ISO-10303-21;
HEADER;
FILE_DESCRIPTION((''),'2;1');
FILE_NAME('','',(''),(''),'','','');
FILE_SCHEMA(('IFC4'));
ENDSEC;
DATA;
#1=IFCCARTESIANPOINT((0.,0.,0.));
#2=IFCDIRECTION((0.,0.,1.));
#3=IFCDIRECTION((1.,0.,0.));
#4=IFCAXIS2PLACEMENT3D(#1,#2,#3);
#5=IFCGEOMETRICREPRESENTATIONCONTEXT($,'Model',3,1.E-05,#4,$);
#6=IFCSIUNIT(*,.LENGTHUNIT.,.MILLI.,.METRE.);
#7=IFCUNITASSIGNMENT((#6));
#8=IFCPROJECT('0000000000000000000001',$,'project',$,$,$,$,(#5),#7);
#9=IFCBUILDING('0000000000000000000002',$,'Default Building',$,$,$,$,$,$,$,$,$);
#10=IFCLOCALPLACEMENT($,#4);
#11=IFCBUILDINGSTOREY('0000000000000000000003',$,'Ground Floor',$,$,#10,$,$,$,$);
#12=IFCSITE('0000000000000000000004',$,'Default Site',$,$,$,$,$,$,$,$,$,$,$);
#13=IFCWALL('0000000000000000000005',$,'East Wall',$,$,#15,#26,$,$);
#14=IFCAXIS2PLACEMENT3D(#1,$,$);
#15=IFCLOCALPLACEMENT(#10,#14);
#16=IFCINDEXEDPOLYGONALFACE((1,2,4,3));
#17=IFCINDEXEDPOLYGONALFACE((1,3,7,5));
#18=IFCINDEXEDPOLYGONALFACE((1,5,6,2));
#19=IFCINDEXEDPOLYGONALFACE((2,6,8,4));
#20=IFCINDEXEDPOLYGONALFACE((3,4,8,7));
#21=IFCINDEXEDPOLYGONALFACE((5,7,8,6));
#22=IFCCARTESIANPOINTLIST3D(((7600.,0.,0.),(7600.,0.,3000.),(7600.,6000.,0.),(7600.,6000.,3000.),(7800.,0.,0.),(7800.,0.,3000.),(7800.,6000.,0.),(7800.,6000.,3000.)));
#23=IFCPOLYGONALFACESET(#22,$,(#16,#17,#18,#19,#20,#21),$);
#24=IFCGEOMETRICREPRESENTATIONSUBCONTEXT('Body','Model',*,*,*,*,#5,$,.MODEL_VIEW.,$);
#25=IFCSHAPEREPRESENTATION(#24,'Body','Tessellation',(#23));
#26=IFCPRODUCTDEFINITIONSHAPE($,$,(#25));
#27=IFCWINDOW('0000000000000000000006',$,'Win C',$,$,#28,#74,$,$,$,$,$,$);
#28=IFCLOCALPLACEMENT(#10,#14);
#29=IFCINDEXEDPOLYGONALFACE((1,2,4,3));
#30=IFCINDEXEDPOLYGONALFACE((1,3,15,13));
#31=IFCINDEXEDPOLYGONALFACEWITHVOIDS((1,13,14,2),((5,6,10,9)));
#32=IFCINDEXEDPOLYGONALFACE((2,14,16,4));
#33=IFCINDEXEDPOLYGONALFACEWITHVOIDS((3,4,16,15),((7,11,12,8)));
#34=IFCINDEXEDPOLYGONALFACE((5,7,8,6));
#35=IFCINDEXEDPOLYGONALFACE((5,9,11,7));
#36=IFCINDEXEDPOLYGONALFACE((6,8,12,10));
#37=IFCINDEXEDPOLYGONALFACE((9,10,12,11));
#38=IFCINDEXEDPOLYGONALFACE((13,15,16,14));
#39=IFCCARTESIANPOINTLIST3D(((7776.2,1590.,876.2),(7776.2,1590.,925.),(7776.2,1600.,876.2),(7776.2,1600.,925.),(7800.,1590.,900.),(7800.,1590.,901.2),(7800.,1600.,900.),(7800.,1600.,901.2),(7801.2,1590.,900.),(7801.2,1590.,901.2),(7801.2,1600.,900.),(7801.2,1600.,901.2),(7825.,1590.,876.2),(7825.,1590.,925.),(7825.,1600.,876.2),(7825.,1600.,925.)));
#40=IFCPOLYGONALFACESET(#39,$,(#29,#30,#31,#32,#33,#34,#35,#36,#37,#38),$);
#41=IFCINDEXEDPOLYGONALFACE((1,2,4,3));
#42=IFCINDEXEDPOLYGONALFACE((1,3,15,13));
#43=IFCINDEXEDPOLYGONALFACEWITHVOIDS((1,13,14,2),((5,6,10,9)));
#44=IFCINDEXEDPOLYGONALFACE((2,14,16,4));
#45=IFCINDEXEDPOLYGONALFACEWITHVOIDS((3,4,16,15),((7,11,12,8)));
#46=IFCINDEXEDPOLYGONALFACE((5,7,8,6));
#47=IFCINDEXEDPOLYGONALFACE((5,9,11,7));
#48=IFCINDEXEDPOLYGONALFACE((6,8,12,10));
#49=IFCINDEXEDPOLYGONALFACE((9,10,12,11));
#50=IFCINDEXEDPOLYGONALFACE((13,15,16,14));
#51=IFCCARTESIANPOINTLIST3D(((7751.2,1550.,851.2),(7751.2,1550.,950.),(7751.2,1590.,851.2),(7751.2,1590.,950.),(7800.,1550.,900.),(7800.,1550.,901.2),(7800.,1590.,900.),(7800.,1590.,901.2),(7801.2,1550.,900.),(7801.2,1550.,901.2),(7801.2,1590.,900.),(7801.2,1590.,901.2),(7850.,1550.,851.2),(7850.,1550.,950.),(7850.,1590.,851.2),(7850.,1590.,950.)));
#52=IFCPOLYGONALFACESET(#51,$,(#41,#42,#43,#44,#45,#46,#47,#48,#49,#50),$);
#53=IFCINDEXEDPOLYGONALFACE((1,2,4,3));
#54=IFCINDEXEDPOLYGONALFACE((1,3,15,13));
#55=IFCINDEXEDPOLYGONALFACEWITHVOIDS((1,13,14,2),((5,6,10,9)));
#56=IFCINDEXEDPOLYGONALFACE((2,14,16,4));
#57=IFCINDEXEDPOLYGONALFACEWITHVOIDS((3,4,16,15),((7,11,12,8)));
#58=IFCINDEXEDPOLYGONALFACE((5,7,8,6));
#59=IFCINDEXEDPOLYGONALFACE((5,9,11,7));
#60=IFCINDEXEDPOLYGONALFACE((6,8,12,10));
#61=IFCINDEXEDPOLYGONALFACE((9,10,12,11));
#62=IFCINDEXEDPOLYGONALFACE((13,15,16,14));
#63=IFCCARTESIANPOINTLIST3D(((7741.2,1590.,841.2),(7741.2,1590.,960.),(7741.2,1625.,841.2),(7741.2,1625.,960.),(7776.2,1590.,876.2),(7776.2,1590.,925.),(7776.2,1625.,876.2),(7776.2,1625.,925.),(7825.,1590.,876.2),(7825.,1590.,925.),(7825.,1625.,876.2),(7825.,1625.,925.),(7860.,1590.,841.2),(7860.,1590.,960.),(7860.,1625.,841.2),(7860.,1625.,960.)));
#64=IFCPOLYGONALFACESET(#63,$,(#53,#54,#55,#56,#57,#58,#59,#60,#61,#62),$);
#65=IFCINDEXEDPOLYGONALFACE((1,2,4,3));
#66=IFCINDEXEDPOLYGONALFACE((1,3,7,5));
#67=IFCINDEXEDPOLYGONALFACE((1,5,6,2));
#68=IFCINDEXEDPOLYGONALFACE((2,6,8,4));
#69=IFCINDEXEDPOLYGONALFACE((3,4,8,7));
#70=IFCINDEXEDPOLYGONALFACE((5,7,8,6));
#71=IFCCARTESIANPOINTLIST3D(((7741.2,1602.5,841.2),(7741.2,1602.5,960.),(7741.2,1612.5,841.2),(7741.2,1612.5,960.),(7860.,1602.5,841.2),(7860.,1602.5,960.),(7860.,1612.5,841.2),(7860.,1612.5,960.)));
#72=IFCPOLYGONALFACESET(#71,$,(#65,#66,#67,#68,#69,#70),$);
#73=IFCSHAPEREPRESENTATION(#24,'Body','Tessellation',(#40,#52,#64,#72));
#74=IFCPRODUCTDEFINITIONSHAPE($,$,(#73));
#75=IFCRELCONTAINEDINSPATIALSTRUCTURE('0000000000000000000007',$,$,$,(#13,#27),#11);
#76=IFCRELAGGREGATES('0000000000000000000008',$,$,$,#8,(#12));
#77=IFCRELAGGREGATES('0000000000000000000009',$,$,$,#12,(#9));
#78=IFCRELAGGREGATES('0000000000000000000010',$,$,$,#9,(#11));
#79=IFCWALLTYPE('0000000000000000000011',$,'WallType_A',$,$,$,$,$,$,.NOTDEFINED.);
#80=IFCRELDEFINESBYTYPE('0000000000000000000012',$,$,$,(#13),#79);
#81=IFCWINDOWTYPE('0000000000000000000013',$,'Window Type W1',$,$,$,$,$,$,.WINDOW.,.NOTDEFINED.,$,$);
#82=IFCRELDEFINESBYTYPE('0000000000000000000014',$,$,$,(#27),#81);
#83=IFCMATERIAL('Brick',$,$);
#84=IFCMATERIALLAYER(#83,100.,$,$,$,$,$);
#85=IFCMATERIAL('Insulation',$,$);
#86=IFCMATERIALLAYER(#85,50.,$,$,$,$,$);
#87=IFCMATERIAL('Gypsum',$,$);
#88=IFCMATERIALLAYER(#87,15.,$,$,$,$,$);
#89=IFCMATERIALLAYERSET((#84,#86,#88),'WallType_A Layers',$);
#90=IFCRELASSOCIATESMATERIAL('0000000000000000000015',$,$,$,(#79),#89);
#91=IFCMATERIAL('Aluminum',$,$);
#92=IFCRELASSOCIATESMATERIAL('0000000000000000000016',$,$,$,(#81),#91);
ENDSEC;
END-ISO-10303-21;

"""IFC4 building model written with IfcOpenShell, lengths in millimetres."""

from ifc_helpers import new_model, si_unit, frame, origin_with_axes, place, context, subcontext, project, spatial, line, indexed_curve, outline, extrude, material, layer, layer_set, type_object, element, fill, save


model = new_model("IFC4")

# Units and contexts
model_context = context("Model", 3, precision=1e-05, world=origin_with_axes())
body_context = subcontext(model_context, "Body", "Model", "MODEL_VIEW")
ifc_project = project(units=[si_unit("LENGTHUNIT", "METRE", prefix="MILLI")], contexts=[model_context])

# Site, building, storey
site = spatial("IfcSite", under=ifc_project, Name="Default Site")
building = spatial("IfcBuilding", under=site, Name="Default Building")
storey_placement = place(None, origin_with_axes())
storey = spatial("IfcBuildingStorey", under=building, at=storey_placement, Name="Ground Floor")

# Shared definitions
ifc_material_1 = material(Name="Brick")
ifc_layer_1 = layer(ifc_material_1, 100.0)
ifc_material_2 = material(Name="Insulation")
ifc_layer_2 = layer(ifc_material_2, 50.0)
ifc_material_3 = material(Name="Gypsum")
ifc_layer_3 = layer(ifc_material_3, 15.0)
ifc_layer_set_1 = layer_set([ifc_layer_1, ifc_layer_2, ifc_layer_3], Name="WallType_A Layers")
wall_type_1 = type_object("IfcWallType", Name="WallType_A", PredefinedType="NOTDEFINED", material=ifc_layer_set_1)

# Wall, opening, window
wall_1_placement = place(storey_placement, origin_with_axes())
wall_1 = element("IfcWall", 1, at=wall_1_placement, inside=storey, type_object=wall_type_1, Name="East Wall", context=body_context, shape_type="SweptSolid", body=[
    extrude(outline(indexed_curve([(7800.0, 0.0), (7800.0, 6000.0), (7600.0, 6000.0), (7600.0, 0.0), (7800.0, 0.0)])), None, (0.0, 0.0, 1.0), 3000.0),
])
opening_1_placement = place(wall_1_placement, frame((0.0, 0.0, 900.0), z_axis=(0.0, 0.0, 1.0), x_axis=(1.0, 0.0, 0.0)))
opening_1 = element("IfcOpeningElement", 2, at=opening_1_placement, cuts=wall_1, context=body_context, shape_type="SweptSolid", body=[
    extrude(outline(indexed_curve([(7800.0, 1500.0), (9000.0, 1500.0), (9000.0, 1700.0), (7800.0, 1700.0), (7800.0, 1500.0)])), None, (0.0, 0.0, 1.0), 1200.0),
])
ifc_material_4 = material(Name="Aluminum")
window_type_1 = type_object("IfcWindowType", Name="Window Type W1", PartitioningType="NOTDEFINED", PredefinedType="WINDOW", material=ifc_material_4)
window_1_placement = place(storey_placement, frame((7800.0, 1500.0, 900.0), z_axis=(0.0, 0.0, 1.0), x_axis=(1.0, 0.0, 0.0)))
window_1 = element("IfcWindow", 3, at=window_1_placement, inside=storey, type_object=window_type_1, Name="Win C", context=body_context, shape_type="SweptSolid", body=[
    extrude(outline(indexed_curve([(0.0, 0.0), (1.2, 0.0), (1.2, 1.2), (0.0, 1.2)], segments=[line(1, 2, 3, 4, 1)]), holes=[indexed_curve([(25.0, 25.0), (-23.8, 25.0), (-23.8, -23.8), (25.0, -23.8)], segments=[line(1, 2, 3, 4, 1)])]), frame((0.0, 90.0, 0.0), z_axis=(0.0, -1.0, 0.0), x_axis=(1.0, 0.0, 0.0)), (0.0, 0.0, -1.0), 10.0),
    extrude(outline(indexed_curve([(0.0, 0.0), (1.2, 0.0), (1.2, 1.2), (0.0, 1.2)], segments=[line(1, 2, 3, 4, 1)]), holes=[indexed_curve([(50.0, 50.0), (-48.8, 50.0), (-48.8, -48.8), (50.0, -48.8)], segments=[line(1, 2, 3, 4, 1)])]), frame((0.0, 50.0, 0.0), z_axis=(0.0, -1.0, 0.0), x_axis=(1.0, 0.0, 0.0)), (0.0, 0.0, -1.0), 40.0),
    extrude(outline(indexed_curve([(0.0, 0.0), (-48.8, 0.0), (-48.8, -48.8), (0.0, -48.8)], segments=[line(1, 2, 3, 4, 1)]), holes=[indexed_curve([(35.0, 35.0), (-83.8, 35.0), (-83.8, -83.8), (35.0, -83.8)], segments=[line(1, 2, 3, 4, 1)])]), frame((25.0, 90.0, 25.0), z_axis=(0.0, -1.0, 0.0), x_axis=(1.0, 0.0, 0.0)), (0.0, 0.0, -1.0), 35.0),
    extrude(outline(indexed_curve([(35.0, 35.0), (-83.8, 35.0), (-83.8, -83.8), (35.0, -83.8)], segments=[line(1, 2, 3, 4, 1)])), frame((25.0, 102.5, 25.0), z_axis=(0.0, -1.0, 0.0), x_axis=(1.0, 0.0, 0.0)), (0.0, 0.0, -1.0), 10.0),
])
fill(opening_1, window_1)

save(model, "model.ifc")
